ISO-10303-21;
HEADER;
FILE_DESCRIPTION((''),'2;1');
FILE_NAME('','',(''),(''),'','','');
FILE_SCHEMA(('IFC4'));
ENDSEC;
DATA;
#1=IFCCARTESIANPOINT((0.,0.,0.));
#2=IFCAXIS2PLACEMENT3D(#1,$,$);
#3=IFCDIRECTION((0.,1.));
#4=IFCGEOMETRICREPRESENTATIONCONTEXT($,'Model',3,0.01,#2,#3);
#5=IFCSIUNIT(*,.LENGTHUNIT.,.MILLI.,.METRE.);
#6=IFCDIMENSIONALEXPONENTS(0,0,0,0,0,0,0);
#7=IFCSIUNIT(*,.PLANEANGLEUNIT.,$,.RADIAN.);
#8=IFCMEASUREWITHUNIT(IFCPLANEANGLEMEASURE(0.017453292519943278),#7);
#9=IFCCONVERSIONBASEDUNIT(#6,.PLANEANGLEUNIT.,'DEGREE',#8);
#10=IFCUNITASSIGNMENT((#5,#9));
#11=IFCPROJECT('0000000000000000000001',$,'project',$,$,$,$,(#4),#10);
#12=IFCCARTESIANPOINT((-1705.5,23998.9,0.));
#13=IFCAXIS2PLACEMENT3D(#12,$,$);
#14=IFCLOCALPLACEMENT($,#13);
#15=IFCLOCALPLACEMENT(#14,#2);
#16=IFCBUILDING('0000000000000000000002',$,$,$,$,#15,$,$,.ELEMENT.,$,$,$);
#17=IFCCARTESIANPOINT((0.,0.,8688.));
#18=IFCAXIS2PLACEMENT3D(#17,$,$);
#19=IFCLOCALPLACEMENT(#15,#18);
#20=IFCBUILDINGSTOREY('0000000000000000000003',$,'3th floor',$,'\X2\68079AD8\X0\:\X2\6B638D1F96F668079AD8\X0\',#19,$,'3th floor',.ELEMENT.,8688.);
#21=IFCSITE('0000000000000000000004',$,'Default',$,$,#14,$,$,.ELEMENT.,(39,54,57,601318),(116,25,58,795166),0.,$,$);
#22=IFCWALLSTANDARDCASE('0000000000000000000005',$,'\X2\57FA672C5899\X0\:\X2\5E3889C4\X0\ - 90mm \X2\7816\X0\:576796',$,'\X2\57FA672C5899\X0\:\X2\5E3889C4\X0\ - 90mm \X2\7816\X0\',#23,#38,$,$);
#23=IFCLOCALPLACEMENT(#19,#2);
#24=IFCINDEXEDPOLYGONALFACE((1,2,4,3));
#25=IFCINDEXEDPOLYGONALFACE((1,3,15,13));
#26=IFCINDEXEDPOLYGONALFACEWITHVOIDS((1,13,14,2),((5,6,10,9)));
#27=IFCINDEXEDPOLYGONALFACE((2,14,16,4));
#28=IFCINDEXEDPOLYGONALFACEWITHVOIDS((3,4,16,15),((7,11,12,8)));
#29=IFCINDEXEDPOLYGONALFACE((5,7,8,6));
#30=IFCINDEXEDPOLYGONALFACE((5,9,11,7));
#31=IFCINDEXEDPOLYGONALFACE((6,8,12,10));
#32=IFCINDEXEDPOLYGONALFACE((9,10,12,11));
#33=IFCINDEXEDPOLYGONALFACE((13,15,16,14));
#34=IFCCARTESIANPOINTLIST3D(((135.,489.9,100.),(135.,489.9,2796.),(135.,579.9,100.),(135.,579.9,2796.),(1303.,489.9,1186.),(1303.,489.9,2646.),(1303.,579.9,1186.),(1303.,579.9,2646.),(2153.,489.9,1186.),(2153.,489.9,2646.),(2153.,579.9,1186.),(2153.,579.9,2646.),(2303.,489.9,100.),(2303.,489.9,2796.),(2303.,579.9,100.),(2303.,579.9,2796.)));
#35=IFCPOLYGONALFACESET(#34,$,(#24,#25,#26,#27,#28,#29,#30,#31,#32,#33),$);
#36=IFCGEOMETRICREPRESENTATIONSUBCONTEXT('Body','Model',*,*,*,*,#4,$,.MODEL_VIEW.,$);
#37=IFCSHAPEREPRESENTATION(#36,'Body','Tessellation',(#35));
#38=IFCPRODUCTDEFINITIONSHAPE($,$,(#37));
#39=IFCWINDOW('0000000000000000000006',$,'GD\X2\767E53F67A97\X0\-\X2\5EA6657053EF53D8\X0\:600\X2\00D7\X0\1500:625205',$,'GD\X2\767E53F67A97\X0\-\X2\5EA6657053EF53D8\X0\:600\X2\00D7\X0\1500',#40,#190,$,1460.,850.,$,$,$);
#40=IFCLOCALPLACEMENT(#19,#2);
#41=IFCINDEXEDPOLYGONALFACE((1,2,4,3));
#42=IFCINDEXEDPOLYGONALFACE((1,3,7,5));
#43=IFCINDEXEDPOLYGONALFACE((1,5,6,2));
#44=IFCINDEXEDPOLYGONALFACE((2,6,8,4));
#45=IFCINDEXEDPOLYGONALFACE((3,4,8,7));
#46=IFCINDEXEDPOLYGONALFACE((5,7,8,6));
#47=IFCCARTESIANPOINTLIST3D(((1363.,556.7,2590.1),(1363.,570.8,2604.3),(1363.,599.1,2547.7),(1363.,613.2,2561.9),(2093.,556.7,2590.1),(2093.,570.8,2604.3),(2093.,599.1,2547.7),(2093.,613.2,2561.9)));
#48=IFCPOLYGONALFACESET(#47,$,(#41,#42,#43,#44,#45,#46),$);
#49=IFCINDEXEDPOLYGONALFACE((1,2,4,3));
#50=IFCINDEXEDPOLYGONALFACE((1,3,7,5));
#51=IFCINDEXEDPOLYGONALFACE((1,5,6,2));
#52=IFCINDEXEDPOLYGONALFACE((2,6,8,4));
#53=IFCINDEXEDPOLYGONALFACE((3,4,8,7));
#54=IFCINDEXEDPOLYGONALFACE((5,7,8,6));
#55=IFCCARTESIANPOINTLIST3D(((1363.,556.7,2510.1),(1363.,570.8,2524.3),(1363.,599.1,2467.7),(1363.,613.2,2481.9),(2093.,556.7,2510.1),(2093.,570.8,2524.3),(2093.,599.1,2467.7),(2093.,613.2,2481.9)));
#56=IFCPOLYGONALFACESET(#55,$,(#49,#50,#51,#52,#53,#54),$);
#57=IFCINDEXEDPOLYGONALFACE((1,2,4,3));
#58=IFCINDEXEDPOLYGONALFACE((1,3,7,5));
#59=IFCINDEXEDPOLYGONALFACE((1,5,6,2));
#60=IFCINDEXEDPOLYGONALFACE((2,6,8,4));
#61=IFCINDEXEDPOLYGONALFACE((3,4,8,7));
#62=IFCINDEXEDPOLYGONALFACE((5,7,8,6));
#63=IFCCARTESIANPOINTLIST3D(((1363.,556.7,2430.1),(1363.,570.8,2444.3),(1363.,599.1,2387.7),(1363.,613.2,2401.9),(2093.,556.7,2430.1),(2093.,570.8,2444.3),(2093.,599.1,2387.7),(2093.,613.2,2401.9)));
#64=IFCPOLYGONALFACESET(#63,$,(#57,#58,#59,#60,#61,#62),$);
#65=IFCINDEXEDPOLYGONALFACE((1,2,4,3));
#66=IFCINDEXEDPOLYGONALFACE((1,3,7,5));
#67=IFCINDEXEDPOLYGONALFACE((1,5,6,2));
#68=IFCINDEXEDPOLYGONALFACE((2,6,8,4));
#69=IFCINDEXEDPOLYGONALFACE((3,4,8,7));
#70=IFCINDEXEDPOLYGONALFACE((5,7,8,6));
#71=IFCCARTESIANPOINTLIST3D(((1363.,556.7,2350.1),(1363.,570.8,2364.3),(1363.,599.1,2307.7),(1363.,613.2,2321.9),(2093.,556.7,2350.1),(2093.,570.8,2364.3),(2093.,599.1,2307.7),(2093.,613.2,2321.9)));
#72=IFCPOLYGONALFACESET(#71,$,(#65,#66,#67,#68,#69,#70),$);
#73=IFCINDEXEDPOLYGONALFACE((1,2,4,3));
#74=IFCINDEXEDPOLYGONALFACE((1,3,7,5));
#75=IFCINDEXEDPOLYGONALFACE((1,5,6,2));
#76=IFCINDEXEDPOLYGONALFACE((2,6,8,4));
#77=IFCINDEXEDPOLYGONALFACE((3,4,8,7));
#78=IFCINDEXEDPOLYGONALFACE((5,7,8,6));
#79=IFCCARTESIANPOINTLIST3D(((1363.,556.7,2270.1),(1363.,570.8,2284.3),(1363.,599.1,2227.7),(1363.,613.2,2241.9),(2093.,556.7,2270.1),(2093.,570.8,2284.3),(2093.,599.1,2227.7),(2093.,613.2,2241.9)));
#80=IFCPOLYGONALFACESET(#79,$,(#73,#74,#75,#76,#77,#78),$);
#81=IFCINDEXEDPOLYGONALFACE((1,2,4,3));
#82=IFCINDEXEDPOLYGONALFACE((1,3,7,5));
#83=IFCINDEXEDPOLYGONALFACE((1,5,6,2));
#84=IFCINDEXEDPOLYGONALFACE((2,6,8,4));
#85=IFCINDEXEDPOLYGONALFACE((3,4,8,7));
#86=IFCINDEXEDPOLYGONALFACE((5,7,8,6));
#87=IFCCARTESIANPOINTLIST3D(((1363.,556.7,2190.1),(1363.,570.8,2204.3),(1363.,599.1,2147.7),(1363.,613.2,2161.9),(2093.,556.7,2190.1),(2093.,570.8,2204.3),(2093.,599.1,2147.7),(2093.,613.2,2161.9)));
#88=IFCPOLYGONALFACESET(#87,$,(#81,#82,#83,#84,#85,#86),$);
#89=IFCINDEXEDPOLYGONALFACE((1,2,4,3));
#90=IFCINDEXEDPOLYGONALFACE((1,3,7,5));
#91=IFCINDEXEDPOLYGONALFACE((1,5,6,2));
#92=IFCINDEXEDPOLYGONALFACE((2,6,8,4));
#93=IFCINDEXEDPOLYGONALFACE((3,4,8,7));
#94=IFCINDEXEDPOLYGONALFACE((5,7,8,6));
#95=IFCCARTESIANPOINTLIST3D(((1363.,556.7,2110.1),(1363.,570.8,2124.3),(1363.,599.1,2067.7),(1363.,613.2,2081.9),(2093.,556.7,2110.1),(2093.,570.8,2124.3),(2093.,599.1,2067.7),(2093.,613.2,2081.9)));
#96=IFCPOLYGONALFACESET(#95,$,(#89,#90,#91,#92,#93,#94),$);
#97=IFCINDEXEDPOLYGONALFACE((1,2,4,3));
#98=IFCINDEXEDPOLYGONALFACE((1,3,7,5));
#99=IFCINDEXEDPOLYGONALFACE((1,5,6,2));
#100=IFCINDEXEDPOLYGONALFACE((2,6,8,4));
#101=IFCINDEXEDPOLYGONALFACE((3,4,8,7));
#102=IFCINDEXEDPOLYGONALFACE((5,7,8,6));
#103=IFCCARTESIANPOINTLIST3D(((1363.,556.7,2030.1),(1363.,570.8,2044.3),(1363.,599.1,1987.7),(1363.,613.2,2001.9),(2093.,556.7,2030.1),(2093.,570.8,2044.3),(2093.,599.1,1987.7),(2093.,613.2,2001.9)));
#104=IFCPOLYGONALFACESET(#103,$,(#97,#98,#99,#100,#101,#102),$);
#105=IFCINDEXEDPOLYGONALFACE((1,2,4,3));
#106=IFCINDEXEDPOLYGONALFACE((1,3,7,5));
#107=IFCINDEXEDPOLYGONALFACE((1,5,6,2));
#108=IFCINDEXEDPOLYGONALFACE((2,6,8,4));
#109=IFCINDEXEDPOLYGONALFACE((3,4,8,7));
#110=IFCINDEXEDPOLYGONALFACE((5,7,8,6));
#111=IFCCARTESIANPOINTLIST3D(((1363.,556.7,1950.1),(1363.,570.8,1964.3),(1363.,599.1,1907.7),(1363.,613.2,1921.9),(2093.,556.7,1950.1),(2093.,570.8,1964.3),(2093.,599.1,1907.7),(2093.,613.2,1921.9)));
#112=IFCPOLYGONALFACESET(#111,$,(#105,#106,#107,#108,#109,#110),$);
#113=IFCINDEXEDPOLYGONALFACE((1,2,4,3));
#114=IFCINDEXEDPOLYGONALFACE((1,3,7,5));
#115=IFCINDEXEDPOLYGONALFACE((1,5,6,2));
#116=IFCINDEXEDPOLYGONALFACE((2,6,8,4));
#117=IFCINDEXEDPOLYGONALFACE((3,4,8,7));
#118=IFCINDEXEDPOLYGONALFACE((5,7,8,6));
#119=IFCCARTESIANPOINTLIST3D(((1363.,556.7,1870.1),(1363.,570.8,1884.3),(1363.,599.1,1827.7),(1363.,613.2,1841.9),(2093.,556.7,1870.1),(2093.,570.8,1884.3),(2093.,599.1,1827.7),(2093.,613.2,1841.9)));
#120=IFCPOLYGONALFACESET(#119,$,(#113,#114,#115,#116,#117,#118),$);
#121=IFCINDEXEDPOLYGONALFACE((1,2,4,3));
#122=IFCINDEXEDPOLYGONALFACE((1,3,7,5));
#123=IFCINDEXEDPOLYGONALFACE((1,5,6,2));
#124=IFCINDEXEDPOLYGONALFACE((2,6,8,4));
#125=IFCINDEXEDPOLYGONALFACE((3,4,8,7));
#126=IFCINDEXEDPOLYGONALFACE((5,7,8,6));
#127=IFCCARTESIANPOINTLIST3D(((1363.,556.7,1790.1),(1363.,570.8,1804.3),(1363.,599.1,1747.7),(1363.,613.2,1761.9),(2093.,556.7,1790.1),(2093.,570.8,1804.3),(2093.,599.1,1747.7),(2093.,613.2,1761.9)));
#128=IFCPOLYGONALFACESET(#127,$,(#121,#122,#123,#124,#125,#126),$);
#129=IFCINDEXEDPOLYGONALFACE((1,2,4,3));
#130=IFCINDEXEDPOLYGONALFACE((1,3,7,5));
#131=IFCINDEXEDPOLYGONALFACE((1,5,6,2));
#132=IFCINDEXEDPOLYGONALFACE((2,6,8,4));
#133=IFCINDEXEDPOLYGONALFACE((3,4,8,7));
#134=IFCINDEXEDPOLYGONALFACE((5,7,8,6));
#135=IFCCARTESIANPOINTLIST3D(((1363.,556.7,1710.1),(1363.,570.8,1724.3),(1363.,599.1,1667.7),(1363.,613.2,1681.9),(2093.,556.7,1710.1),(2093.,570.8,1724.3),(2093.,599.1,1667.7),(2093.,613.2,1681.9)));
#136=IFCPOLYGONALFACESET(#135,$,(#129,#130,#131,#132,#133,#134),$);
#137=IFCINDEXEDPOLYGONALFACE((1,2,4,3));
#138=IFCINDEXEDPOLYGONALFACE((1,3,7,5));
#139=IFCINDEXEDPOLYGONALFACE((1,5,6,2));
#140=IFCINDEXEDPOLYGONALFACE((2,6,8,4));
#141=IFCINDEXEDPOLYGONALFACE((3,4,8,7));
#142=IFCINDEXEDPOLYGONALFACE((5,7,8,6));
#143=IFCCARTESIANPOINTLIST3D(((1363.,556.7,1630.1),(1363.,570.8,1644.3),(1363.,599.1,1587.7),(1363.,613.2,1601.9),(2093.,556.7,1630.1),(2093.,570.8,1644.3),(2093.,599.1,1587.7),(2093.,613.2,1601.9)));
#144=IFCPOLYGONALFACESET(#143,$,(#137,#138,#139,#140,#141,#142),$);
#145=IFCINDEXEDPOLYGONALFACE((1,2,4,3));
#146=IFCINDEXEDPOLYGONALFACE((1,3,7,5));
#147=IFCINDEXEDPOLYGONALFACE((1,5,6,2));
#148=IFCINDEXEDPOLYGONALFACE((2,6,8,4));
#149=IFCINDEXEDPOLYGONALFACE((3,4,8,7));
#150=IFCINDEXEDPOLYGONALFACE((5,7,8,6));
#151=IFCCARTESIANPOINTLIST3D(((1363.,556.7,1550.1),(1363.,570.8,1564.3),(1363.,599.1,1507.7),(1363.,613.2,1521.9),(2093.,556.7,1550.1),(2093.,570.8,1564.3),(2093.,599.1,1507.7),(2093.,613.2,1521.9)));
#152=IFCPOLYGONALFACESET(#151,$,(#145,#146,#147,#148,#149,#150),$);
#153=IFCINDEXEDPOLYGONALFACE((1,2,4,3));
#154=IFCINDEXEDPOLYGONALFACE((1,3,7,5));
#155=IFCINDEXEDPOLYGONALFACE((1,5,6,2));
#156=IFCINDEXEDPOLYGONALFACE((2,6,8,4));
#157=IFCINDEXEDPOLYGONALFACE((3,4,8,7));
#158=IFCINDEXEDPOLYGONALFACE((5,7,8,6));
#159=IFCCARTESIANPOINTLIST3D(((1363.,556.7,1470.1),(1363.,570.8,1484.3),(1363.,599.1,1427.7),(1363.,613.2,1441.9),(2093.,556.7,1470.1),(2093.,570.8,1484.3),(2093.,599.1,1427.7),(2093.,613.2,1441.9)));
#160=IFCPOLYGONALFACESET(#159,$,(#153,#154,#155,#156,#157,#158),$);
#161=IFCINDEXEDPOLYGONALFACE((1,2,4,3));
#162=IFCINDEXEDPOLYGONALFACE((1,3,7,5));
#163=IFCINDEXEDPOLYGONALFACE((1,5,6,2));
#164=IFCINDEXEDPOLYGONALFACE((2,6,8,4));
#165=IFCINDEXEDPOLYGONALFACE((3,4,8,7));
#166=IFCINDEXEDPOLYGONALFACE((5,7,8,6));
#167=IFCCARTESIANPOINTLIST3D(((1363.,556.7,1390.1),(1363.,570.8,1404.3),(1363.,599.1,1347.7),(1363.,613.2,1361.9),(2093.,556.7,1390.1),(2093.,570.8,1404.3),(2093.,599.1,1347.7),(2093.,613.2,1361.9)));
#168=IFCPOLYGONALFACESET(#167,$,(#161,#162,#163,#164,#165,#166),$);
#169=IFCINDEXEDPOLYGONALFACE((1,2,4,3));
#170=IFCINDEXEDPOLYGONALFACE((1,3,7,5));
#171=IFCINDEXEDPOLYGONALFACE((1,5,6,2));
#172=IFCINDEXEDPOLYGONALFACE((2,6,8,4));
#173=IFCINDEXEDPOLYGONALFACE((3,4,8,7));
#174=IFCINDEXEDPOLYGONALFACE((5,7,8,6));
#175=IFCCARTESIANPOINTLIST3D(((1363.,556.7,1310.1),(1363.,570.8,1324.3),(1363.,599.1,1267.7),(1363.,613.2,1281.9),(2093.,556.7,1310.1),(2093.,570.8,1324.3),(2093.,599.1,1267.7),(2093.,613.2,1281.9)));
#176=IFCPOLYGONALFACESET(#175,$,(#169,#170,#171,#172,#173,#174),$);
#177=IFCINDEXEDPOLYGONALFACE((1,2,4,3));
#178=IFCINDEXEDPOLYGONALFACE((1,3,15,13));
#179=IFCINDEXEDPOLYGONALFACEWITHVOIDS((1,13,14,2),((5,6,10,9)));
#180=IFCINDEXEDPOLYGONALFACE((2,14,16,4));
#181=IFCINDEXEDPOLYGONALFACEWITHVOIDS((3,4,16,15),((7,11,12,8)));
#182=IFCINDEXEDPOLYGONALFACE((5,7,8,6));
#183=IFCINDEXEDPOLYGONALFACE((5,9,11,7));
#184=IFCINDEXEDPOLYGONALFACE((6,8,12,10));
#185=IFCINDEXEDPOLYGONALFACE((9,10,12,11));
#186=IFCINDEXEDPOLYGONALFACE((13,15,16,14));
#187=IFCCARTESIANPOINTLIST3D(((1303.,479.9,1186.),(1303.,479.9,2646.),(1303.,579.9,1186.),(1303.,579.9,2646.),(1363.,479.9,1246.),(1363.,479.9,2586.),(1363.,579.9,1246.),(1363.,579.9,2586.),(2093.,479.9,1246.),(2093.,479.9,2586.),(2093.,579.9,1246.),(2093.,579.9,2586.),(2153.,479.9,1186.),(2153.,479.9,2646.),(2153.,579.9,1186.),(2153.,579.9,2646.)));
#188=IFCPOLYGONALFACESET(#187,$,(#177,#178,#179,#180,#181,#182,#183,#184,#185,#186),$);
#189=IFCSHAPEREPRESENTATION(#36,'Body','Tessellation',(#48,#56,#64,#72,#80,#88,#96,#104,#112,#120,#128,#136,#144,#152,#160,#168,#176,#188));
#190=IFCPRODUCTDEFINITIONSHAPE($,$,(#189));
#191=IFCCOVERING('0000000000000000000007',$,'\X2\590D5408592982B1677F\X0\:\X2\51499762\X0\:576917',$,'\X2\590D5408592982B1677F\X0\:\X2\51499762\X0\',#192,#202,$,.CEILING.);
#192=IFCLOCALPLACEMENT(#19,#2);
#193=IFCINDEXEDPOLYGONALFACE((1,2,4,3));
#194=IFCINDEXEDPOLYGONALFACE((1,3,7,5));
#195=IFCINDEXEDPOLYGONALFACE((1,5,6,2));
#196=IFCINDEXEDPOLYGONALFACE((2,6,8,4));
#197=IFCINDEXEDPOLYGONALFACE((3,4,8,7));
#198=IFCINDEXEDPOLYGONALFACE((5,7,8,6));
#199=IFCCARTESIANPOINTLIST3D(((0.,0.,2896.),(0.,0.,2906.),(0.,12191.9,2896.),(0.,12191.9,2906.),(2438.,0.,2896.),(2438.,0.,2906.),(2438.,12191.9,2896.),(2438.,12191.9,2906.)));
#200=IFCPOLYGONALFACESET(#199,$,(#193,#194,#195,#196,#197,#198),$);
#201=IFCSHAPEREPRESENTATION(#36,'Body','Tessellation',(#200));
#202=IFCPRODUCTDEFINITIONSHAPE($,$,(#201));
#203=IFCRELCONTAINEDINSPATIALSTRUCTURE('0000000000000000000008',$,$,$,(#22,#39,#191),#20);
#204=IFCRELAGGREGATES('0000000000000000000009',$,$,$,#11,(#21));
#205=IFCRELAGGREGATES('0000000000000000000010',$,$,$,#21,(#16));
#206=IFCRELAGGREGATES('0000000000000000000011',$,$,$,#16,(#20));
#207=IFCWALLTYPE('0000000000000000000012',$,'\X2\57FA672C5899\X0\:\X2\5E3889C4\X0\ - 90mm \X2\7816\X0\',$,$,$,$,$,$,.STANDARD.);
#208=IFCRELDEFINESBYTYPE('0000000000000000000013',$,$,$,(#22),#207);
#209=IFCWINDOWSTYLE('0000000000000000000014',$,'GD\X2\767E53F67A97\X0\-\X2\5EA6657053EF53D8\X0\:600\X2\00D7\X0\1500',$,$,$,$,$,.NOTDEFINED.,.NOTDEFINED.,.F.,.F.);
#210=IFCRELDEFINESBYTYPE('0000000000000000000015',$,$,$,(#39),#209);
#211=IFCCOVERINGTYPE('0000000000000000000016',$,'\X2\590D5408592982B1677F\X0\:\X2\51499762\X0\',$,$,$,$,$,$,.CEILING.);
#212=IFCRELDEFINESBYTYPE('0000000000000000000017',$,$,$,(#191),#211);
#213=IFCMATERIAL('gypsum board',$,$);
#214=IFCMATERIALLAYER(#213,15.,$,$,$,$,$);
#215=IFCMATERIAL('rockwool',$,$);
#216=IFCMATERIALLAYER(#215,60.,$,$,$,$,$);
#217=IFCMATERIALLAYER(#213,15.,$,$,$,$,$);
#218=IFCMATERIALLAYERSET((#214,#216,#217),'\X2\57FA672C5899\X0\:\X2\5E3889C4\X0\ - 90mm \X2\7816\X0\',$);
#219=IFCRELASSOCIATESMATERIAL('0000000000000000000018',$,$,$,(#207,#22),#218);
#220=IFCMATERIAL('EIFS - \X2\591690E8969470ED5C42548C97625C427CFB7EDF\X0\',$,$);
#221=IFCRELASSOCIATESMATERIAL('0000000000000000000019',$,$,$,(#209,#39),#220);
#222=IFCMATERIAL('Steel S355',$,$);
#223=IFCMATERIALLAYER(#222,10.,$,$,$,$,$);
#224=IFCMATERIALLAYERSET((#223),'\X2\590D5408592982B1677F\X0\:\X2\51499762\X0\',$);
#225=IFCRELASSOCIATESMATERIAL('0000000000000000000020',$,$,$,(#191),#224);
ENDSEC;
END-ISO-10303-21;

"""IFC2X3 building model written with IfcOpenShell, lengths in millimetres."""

from ifc_helpers import new_model, entity, si_unit, converted_unit, direction, frame, frame_2d, origin, origin_2d_with_axis, place, context, subcontext, project, spatial, polyline, rectangle, outline, extrude, source, transform, mapped, material, layer, layer_set, layer_usage, type_object, type_shapes, element, fill, save


model = new_model("IFC2X3")

# Units and contexts
model_context = context("Model", 3, precision=0.01, world=origin(), true_north=direction((0.0, 1.0)))
body_context = subcontext(model_context, "Body", "Model", "MODEL_VIEW")
ifc_project = project(units=[si_unit("LENGTHUNIT", "METRE", prefix="MILLI"), converted_unit("PLANEANGLEUNIT", "DEGREE", entity("IfcPlaneAngleMeasure", 0.017453292519943278), si_unit("PLANEANGLEUNIT", "RADIAN"), dimensions=[0, 0, 0, 0, 0, 0, 0])], contexts=[model_context])

# Site, building, storey
site_placement = place(None, frame((-1705.5, 23998.9, 0.0)))
site = spatial("IfcSite", under=ifc_project, at=site_placement, Name="Default", CompositionType="ELEMENT", RefLatitude=(39, 54, 57, 601318), RefLongitude=(116, 25, 58, 795166), RefElevation=0.0)
building_placement = place(site_placement, origin())
building = spatial("IfcBuilding", under=site, at=building_placement, CompositionType="ELEMENT")
storey_placement = place(building_placement, frame((0.0, 0.0, 8688.0)))
storey = spatial("IfcBuildingStorey", under=building, at=storey_placement, Name="3th floor", ObjectType="标高:正负零标高", LongName="3th floor", CompositionType="ELEMENT", Elevation=8688.0)

# Shared definitions
ifc_material_1 = material(Name="Steel S355")

# Wall, opening, window
ifc_material_2 = material(Name="gypsum board")
ifc_layer_1 = layer(ifc_material_2, 15.0)
ifc_material_3 = material(Name="rockwool")
ifc_layer_2 = layer(ifc_material_3, 60.0)
ifc_layer_3 = layer(ifc_material_2, 15.0)
ifc_layer_set_1 = layer_set([ifc_layer_1, ifc_layer_2, ifc_layer_3], Name="基本墙:常规 - 90mm 砖")
ifc_layer_usage_1 = layer_usage(ifc_layer_set_1, "AXIS2", "NEGATIVE", 45.0)
wall_type = type_object("IfcWallType", Name="基本墙:常规 - 90mm 砖", PredefinedType="STANDARD", material=ifc_layer_set_1)
wall_placement = place(storey_placement, frame((2303.0, 534.9, 100.0), z_axis=(0.0, 0.0, 1.0), x_axis=(-1.0, 0.0, 0.0)))
wall = element("IfcWallStandardCase", 1, at=wall_placement, inside=storey, type_object=wall_type, material=ifc_layer_usage_1, Name="基本墙:常规 - 90mm 砖:576796", ObjectType="基本墙:常规 - 90mm 砖", context=body_context, shape_type="SweptSolid", body=[
    extrude(rectangle(XDim=2168.0, YDim=90.0, at=frame_2d((1084.0, 0.0), x_axis=(-1.0, 0.0))), origin(), (0.0, 0.0, 1.0), 2696.0),
])
opening_1_placement = place(wall_placement, frame((1000.0, 45.0, 1086.0)))
opening_1 = element("IfcOpeningElement", 2, at=opening_1_placement, cuts=wall, ObjectType="Opening", context=body_context, shape_type="SweptSolid", body=[
    extrude(rectangle(XDim=1460.0, YDim=850.0, at=frame_2d((730.0, 425.0), x_axis=(1.0, 0.0))), frame((0.0, 0.0, 0.0), z_axis=(0.0, -1.0, 0.0), x_axis=(0.0, 0.0, 1.0)), (0.0, 0.0, 1.0), 90.0),
])
ifc_material_4 = material(Name="EIFS - 外部隔热层和面层系统")
window_style = type_object("IfcWindowStyle", Name="GD百叶窗-度数可变:600×1500", ConstructionType="NOTDEFINED", OperationType="NOTDEFINED", ParameterTakesPrecedence=False, Sizeable=False, material=ifc_material_4)
shared_shape = source(origin(), body_context, "Body", "SweptSolid", [
    extrude(rectangle(XDim=60.0, YDim=20.0, at=frame_2d((0.0, 0.0), x_axis=(0.0, 1.0))), frame((790.0, 295.0, 1390.0), z_axis=(-1.0, 0.0, 0.0), x_axis=(0.0, -0.707107, -0.707107)), (0.0, 0.0, 1.0), 730.0),
    extrude(rectangle(XDim=60.0, YDim=20.0, at=frame_2d((0.0, 0.0), x_axis=(0.0, 1.0))), frame((790.0, 295.0, 1310.0), z_axis=(-1.0, 0.0, 0.0), x_axis=(0.0, -0.707107, -0.707107)), (0.0, 0.0, 1.0), 730.0),
    extrude(rectangle(XDim=60.0, YDim=20.0, at=frame_2d((0.0, 0.0), x_axis=(0.0, 1.0))), frame((790.0, 295.0, 1230.0), z_axis=(-1.0, 0.0, 0.0), x_axis=(0.0, -0.707107, -0.707107)), (0.0, 0.0, 1.0), 730.0),
    extrude(rectangle(XDim=60.0, YDim=20.0, at=frame_2d((0.0, 0.0), x_axis=(0.0, 1.0))), frame((790.0, 295.0, 1150.0), z_axis=(-1.0, 0.0, 0.0), x_axis=(0.0, -0.707107, -0.707107)), (0.0, 0.0, 1.0), 730.0),
    extrude(rectangle(XDim=60.0, YDim=20.0, at=frame_2d((0.0, 0.0), x_axis=(0.0, 1.0))), frame((790.0, 295.0, 1070.0), z_axis=(-1.0, 0.0, 0.0), x_axis=(0.0, -0.707107, -0.707107)), (0.0, 0.0, 1.0), 730.0),
    extrude(rectangle(XDim=60.0, YDim=20.0, at=frame_2d((0.0, 0.0), x_axis=(0.0, 1.0))), frame((790.0, 295.0, 990.0), z_axis=(-1.0, 0.0, 0.0), x_axis=(0.0, -0.707107, -0.707107)), (0.0, 0.0, 1.0), 730.0),
    extrude(rectangle(XDim=60.0, YDim=20.0, at=frame_2d((0.0, 0.0), x_axis=(0.0, 1.0))), frame((790.0, 295.0, 910.0), z_axis=(-1.0, 0.0, 0.0), x_axis=(0.0, -0.707107, -0.707107)), (0.0, 0.0, 1.0), 730.0),
    extrude(rectangle(XDim=60.0, YDim=20.0, at=frame_2d((0.0, 0.0), x_axis=(0.0, 1.0))), frame((790.0, 295.0, 830.0), z_axis=(-1.0, 0.0, 0.0), x_axis=(0.0, -0.707107, -0.707107)), (0.0, 0.0, 1.0), 730.0),
    extrude(rectangle(XDim=60.0, YDim=20.0, at=frame_2d((0.0, 0.0), x_axis=(0.0, 1.0))), frame((790.0, 295.0, 750.0), z_axis=(-1.0, 0.0, 0.0), x_axis=(0.0, -0.707107, -0.707107)), (0.0, 0.0, 1.0), 730.0),
    extrude(rectangle(XDim=60.0, YDim=20.0, at=frame_2d((0.0, 0.0), x_axis=(0.0, 1.0))), frame((790.0, 295.0, 670.0), z_axis=(-1.0, 0.0, 0.0), x_axis=(0.0, -0.707107, -0.707107)), (0.0, 0.0, 1.0), 730.0),
    extrude(rectangle(XDim=60.0, YDim=20.0, at=frame_2d((0.0, 0.0), x_axis=(0.0, 1.0))), frame((790.0, 295.0, 590.0), z_axis=(-1.0, 0.0, 0.0), x_axis=(0.0, -0.707107, -0.707107)), (0.0, 0.0, 1.0), 730.0),
    extrude(rectangle(XDim=60.0, YDim=20.0, at=frame_2d((0.0, 0.0), x_axis=(0.0, 1.0))), frame((790.0, 295.0, 510.0), z_axis=(-1.0, 0.0, 0.0), x_axis=(0.0, -0.707107, -0.707107)), (0.0, 0.0, 1.0), 730.0),
    extrude(rectangle(XDim=60.0, YDim=20.0, at=frame_2d((0.0, 0.0), x_axis=(0.0, 1.0))), frame((790.0, 295.0, 430.0), z_axis=(-1.0, 0.0, 0.0), x_axis=(0.0, -0.707107, -0.707107)), (0.0, 0.0, 1.0), 730.0),
    extrude(rectangle(XDim=60.0, YDim=20.0, at=frame_2d((0.0, 0.0), x_axis=(0.0, 1.0))), frame((790.0, 295.0, 350.0), z_axis=(-1.0, 0.0, 0.0), x_axis=(0.0, -0.707107, -0.707107)), (0.0, 0.0, 1.0), 730.0),
    extrude(rectangle(XDim=60.0, YDim=20.0, at=frame_2d((0.0, 0.0), x_axis=(0.0, 1.0))), frame((790.0, 295.0, 270.0), z_axis=(-1.0, 0.0, 0.0), x_axis=(0.0, -0.707107, -0.707107)), (0.0, 0.0, 1.0), 730.0),
    extrude(rectangle(XDim=60.0, YDim=20.0, at=frame_2d((0.0, 0.0), x_axis=(0.0, 1.0))), frame((790.0, 295.0, 190.0), z_axis=(-1.0, 0.0, 0.0), x_axis=(0.0, -0.707107, -0.707107)), (0.0, 0.0, 1.0), 730.0),
    extrude(rectangle(XDim=60.0, YDim=20.0, at=frame_2d((0.0, 0.0), x_axis=(0.0, 1.0))), frame((790.0, 295.0, 110.0), z_axis=(-1.0, 0.0, 0.0), x_axis=(0.0, -0.707107, -0.707107)), (0.0, 0.0, 1.0), 730.0),
    extrude(outline(polyline([(-425.0, -730.0), (425.0, -730.0), (425.0, 730.0), (-425.0, 730.0), (-425.0, -730.0)]), holes=[polyline([(365.0, -670.0), (-365.0, -670.0), (-365.0, 670.0), (365.0, 670.0), (365.0, -670.0)])]), frame((425.0, 290.0, 730.0), z_axis=(0.0, -1.0, 0.0), x_axis=(-1.0, 0.0, 0.0)), (0.0, 0.0, 1.0), 100.0),
])
type_shapes(window_style, [shared_shape])
window_placement = place(opening_1_placement, frame((0.0, 200.0, 0.0), z_axis=(0.0, 0.0, 1.0), x_axis=(-1.0, 0.0, 0.0)))
window = element("IfcWindow", 3, at=window_placement, inside=storey, type_object=window_style, material=ifc_material_4, Name="GD百叶窗-度数可变:600×1500:625205", ObjectType="GD百叶窗-度数可变:600×1500", OverallHeight=1460.0, OverallWidth=850.0, context=body_context, shape_type="MappedRepresentation", body=[
    mapped(shared_shape, transform((0.0, 0.0, 0.0), scale=1.0)),
])
fill(opening_1, window)

# Covering
ifc_layer_4 = layer(ifc_material_1, 10.0)
ifc_layer_set_2 = layer_set([ifc_layer_4], Name="复合天花板:光面")
ifc_layer_usage_2 = layer_usage(ifc_layer_set_2, "AXIS3", "NEGATIVE", 10.0)
covering_type = type_object("IfcCoveringType", Name="复合天花板:光面", PredefinedType="CEILING")
covering_placement = place(storey_placement, origin())
element("IfcCovering", 4, at=covering_placement, inside=storey, type_object=covering_type, material=ifc_layer_usage_2, Name="复合天花板:光面:576917", ObjectType="复合天花板:光面", PredefinedType="CEILING", context=body_context, shape_type="SweptSolid", body=[
    extrude(rectangle(XDim=12191.9, YDim=2438.0, at=origin_2d_with_axis()), frame((1219.0, 6096.0, 2896.0), z_axis=(0.0, 0.0, 1.0), x_axis=(0.0, 1.0, 0.0)), (0.0, 0.0, 1.0), 10.0),
])

save(model, "model.ifc")
